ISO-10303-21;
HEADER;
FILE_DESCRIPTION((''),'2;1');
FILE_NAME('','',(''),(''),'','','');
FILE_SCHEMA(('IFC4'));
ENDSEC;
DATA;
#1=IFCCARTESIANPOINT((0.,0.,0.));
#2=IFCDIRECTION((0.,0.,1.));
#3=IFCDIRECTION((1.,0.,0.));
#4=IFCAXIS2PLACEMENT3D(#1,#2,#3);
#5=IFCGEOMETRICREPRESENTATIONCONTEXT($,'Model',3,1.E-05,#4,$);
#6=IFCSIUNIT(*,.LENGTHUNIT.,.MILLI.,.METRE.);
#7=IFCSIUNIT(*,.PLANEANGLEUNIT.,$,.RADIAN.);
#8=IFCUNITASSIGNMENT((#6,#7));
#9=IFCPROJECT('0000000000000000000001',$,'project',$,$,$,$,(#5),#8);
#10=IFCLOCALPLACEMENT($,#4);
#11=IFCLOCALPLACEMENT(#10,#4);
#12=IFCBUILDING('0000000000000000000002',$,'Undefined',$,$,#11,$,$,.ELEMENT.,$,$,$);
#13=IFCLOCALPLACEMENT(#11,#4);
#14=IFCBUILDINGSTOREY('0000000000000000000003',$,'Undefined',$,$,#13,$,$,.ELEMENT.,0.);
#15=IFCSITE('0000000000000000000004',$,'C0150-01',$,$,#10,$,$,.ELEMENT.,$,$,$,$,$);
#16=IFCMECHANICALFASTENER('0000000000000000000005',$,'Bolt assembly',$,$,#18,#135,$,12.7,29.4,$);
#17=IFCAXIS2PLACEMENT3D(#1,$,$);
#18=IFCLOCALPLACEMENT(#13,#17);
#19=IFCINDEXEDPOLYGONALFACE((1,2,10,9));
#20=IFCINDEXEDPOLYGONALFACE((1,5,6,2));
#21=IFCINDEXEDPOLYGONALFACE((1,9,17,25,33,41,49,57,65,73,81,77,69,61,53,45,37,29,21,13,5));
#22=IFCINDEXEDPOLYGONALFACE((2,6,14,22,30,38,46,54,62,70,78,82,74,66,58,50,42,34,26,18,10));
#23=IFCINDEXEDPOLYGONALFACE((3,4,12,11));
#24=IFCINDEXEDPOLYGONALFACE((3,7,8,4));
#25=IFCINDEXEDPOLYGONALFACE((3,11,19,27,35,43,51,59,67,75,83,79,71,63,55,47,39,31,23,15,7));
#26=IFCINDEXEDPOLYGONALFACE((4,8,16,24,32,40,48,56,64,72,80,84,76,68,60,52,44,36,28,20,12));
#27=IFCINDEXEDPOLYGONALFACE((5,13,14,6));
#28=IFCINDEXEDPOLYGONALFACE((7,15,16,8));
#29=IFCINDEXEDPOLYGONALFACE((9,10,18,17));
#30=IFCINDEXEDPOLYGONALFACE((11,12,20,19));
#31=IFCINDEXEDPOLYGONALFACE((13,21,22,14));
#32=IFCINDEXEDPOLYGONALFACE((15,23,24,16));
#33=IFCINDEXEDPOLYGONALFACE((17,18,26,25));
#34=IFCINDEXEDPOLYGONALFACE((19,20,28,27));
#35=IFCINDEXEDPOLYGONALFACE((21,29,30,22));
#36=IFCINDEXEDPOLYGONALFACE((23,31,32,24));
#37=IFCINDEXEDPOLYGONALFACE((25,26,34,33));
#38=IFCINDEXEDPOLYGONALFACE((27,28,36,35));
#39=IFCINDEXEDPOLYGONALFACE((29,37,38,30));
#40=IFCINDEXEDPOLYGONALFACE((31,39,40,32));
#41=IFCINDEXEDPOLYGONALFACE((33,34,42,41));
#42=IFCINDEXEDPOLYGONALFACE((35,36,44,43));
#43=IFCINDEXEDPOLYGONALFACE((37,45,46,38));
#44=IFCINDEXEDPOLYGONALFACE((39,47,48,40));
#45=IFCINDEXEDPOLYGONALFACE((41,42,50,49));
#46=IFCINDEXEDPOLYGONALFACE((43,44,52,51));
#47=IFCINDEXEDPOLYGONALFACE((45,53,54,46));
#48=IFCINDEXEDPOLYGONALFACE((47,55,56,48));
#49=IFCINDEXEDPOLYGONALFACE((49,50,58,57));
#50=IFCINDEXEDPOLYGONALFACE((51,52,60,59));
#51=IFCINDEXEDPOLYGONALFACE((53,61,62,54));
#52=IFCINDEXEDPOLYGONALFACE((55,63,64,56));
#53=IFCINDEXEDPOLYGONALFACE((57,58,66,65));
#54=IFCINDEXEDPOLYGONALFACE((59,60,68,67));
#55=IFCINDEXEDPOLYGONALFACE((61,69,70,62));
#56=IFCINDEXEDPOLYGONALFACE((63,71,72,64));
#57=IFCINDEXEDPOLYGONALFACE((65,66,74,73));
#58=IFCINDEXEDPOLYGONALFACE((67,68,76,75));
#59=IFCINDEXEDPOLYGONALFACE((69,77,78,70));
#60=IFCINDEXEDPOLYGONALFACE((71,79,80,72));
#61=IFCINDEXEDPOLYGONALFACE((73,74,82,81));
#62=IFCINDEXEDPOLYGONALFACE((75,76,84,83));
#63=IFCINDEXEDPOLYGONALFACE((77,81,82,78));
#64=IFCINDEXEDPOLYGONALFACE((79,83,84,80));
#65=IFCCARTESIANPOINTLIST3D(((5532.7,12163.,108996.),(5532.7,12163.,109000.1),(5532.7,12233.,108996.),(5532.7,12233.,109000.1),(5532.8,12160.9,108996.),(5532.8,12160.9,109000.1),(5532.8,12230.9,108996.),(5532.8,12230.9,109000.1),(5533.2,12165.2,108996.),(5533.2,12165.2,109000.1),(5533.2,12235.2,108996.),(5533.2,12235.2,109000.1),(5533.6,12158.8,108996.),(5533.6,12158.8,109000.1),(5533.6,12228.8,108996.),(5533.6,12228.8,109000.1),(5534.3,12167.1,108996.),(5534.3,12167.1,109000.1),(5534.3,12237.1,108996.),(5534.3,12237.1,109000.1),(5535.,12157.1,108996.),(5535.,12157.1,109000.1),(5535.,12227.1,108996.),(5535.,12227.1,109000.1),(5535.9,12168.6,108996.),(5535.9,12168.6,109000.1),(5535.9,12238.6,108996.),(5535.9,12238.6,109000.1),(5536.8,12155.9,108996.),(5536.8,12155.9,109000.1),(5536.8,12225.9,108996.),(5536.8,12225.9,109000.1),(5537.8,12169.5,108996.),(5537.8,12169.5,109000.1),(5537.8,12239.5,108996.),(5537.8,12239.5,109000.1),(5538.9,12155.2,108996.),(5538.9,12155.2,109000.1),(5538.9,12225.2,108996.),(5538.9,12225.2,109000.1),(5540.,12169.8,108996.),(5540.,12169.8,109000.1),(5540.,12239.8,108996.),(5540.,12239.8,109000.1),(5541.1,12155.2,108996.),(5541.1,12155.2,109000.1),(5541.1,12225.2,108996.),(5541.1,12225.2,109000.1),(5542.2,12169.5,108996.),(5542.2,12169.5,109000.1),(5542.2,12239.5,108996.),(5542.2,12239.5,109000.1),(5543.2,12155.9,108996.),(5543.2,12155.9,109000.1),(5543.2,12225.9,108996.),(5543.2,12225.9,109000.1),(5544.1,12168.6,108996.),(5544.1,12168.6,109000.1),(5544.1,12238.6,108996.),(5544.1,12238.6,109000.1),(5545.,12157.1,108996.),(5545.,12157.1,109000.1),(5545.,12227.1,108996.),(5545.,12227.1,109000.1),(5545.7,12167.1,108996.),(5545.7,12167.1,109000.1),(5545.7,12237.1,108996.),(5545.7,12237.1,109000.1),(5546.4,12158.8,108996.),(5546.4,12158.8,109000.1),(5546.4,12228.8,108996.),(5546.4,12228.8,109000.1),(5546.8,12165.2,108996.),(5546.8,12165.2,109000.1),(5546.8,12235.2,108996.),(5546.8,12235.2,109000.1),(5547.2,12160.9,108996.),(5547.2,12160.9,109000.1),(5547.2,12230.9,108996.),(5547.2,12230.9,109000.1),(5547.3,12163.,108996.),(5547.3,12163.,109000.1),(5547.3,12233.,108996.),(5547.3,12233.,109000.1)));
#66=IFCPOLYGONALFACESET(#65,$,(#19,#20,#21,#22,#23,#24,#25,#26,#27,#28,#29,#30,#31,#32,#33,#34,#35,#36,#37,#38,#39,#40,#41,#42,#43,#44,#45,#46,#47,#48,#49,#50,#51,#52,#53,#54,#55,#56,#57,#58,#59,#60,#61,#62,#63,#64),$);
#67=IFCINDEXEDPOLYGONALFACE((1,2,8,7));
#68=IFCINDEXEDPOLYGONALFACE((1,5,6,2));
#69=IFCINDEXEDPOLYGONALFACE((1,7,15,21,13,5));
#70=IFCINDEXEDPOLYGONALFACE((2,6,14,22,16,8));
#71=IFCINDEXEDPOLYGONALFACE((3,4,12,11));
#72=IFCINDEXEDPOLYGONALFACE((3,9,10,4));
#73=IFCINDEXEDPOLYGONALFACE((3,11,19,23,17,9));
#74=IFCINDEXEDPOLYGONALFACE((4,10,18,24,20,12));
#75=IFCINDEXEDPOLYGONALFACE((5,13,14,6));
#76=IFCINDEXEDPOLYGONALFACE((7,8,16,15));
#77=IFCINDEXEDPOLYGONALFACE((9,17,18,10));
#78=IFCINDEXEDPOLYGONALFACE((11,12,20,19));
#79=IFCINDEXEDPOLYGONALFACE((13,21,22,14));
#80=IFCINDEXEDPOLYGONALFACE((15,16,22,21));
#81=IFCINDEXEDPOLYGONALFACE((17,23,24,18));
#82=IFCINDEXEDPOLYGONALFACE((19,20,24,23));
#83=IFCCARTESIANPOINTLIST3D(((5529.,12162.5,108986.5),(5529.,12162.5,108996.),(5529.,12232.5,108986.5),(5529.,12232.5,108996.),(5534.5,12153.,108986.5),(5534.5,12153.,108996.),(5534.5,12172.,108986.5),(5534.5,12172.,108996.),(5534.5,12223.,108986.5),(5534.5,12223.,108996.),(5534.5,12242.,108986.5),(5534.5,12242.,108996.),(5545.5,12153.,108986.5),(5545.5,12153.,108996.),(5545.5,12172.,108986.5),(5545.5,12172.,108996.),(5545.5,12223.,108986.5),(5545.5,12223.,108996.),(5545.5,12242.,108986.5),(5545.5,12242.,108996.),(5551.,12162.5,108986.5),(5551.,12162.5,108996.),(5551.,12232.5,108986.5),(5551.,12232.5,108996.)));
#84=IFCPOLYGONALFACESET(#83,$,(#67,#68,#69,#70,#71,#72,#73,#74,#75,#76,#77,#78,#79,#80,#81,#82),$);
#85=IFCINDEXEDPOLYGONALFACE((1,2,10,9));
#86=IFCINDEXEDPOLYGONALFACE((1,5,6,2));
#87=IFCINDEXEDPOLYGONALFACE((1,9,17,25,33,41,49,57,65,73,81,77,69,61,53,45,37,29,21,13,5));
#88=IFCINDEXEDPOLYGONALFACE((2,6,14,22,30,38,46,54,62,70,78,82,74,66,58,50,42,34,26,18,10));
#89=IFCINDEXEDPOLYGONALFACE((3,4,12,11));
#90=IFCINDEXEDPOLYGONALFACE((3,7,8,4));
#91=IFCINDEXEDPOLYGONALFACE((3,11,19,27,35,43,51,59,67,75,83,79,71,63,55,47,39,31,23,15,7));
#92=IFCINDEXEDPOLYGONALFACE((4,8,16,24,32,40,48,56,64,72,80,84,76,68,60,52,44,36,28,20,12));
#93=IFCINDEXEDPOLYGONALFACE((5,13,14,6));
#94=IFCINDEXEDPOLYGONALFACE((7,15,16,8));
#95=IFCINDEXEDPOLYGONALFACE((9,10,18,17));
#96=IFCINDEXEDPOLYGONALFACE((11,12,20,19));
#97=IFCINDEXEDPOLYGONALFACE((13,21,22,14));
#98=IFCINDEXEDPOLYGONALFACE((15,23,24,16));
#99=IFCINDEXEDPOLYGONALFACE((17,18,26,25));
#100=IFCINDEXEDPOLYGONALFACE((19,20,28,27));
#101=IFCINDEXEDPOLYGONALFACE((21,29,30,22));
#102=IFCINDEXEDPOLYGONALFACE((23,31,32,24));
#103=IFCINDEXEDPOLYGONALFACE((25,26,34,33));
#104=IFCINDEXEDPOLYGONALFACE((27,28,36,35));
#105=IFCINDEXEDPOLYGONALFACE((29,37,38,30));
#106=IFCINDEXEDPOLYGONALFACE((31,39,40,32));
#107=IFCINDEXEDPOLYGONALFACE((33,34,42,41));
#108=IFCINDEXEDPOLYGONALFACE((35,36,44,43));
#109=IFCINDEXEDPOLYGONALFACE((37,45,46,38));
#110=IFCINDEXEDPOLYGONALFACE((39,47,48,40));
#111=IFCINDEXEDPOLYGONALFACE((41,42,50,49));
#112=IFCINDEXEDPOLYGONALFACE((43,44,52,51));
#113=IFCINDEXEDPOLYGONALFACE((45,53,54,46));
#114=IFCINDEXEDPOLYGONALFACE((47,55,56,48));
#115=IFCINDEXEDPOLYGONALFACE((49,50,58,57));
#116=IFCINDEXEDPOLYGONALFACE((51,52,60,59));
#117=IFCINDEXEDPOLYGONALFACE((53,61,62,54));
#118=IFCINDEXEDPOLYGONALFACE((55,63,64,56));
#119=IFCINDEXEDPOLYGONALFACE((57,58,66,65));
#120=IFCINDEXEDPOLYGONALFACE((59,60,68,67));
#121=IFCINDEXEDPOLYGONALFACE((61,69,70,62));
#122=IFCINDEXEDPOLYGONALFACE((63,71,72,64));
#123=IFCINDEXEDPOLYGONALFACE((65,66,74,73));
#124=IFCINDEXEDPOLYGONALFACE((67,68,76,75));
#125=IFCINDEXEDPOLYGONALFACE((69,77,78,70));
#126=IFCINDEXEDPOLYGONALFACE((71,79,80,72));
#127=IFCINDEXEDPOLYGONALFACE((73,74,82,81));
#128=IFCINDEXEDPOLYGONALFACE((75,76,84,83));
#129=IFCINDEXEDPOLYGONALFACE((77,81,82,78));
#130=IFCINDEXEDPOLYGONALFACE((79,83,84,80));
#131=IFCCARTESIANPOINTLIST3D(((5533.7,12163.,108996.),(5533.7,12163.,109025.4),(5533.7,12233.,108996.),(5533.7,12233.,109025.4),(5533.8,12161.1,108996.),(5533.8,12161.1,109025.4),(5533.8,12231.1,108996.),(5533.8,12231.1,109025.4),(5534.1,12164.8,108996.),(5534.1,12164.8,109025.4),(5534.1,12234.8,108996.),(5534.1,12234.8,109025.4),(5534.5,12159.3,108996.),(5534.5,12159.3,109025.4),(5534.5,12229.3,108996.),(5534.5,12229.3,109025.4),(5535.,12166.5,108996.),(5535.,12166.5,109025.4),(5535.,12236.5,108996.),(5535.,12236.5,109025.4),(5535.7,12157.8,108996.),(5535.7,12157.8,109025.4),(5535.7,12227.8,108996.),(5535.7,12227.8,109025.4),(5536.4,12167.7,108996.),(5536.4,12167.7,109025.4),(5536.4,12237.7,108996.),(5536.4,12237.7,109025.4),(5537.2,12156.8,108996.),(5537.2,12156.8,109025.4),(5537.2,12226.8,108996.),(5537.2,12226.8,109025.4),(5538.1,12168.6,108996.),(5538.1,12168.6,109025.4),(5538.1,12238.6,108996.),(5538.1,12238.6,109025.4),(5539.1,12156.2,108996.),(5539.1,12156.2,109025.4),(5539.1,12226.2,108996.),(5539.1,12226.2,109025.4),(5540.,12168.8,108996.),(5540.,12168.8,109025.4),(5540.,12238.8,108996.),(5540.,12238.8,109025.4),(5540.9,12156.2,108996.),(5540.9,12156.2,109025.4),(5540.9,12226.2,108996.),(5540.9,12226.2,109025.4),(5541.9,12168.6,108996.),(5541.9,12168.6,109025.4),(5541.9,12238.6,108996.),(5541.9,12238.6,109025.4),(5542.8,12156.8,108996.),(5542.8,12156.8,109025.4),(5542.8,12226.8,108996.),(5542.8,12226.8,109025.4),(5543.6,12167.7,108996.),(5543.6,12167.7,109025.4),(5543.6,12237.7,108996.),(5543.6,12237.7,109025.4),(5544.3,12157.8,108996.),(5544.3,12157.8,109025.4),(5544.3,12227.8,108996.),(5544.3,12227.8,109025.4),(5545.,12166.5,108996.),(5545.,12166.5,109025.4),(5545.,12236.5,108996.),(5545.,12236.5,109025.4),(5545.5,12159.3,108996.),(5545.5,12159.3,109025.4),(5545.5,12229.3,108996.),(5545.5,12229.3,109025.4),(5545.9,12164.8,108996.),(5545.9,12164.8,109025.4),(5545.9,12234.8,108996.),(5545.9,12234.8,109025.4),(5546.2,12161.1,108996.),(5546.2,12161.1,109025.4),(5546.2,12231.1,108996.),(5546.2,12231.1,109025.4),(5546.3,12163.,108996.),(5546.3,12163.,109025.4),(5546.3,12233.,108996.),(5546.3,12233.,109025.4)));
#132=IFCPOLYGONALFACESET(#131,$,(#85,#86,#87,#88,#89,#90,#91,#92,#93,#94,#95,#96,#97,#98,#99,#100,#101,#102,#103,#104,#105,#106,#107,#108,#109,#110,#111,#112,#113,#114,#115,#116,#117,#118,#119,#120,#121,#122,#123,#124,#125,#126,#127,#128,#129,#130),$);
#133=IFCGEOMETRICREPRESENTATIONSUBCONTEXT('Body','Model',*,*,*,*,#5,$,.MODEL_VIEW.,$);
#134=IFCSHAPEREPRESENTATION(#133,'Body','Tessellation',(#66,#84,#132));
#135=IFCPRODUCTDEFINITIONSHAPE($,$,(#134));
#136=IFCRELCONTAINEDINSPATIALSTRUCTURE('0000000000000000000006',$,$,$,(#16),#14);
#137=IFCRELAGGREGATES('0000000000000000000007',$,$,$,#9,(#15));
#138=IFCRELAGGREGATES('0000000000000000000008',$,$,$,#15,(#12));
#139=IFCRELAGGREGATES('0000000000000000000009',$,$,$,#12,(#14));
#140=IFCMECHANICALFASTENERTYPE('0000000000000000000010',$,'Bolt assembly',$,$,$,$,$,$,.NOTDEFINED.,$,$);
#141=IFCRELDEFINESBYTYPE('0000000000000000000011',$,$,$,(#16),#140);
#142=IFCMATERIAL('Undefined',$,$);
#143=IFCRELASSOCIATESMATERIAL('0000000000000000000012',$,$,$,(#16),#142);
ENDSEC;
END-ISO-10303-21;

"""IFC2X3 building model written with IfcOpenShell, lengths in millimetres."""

from ifc_helpers import new_model, si_unit, frame, origin_with_axes, origin_2d_with_axis, place, context, subcontext, project, spatial, polyline, circle, outline, extrude, source, transform, mapped, material, type_object, element, save


model = new_model("IFC2X3")

# Units and contexts
model_context = context("Model", 3, precision=1e-05, world=origin_with_axes())
body_context = subcontext(model_context, "Body", "Model", "MODEL_VIEW")
ifc_project = project(units=[si_unit("LENGTHUNIT", "METRE", prefix="MILLI"), si_unit("PLANEANGLEUNIT", "RADIAN")], contexts=[model_context])

# Site, building, storey
site_placement = place(None, origin_with_axes())
site = spatial("IfcSite", under=ifc_project, at=site_placement, Name="C0150-01", CompositionType="ELEMENT")
building_placement = place(site_placement, origin_with_axes())
building = spatial("IfcBuilding", under=site, at=building_placement, Name="Undefined", CompositionType="ELEMENT")
storey_placement = place(building_placement, origin_with_axes())
storey = spatial("IfcBuildingStorey", under=building, at=storey_placement, Name="Undefined", CompositionType="ELEMENT", Elevation=0.0)

# Mechanical fastener
ifc_material_1 = material(Name="Undefined")
mechanical_fastener_type = type_object("IfcMechanicalFastenerType", Name="Bolt assembly")
shared_shape_1 = source(origin_with_axes(), body_context, "Body", "SweptSolid", [
    extrude(circle(Radius=7.3, at=origin_2d_with_axis()), frame((0.0, 0.0, 0.0), z_axis=(0.0, 1.0, 0.0), x_axis=(1.0, 0.0, 0.0)), (0.0, 0.0, 1.0), 4.1),
    extrude(outline(polyline([(9.5, -5.5), (9.5, 5.5), (0.0, 11.0), (-9.5, 5.5), (-9.5, -5.5), (0.0, -11.0), (9.5, -5.5)])), frame((0.0, -9.5, 0.0), z_axis=(0.0, 1.0, 0.0), x_axis=(1.0, 0.0, 0.0)), (0.0, 0.0, 1.0), 9.5),
    extrude(circle(Radius=6.3, at=origin_2d_with_axis()), frame((0.0, 0.0, 0.0), z_axis=(0.0, 1.0, 0.0), x_axis=(1.0, 0.0, 0.0)), (0.0, 0.0, 1.0), 29.4),
])
mechanical_fastener_1_placement = place(storey_placement, frame((5540.0, 12162.5, 108996.0), z_axis=(1.0, 0.0, 0.0), x_axis=(0.0, 1.0, 0.0)))
element("IfcMechanicalFastener", 1, at=mechanical_fastener_1_placement, inside=storey, type_object=mechanical_fastener_type, material=ifc_material_1, Name="Bolt assembly", NominalDiameter=12.7, NominalLength=29.4, context=body_context, shape_type="MappedRepresentation", body=[
    mapped(shared_shape_1, transform((0.0, 0.0, 0.0))),
    mapped(shared_shape_1, transform((70.0, 0.0, 0.0))),
])

save(model, "model.ifc")
